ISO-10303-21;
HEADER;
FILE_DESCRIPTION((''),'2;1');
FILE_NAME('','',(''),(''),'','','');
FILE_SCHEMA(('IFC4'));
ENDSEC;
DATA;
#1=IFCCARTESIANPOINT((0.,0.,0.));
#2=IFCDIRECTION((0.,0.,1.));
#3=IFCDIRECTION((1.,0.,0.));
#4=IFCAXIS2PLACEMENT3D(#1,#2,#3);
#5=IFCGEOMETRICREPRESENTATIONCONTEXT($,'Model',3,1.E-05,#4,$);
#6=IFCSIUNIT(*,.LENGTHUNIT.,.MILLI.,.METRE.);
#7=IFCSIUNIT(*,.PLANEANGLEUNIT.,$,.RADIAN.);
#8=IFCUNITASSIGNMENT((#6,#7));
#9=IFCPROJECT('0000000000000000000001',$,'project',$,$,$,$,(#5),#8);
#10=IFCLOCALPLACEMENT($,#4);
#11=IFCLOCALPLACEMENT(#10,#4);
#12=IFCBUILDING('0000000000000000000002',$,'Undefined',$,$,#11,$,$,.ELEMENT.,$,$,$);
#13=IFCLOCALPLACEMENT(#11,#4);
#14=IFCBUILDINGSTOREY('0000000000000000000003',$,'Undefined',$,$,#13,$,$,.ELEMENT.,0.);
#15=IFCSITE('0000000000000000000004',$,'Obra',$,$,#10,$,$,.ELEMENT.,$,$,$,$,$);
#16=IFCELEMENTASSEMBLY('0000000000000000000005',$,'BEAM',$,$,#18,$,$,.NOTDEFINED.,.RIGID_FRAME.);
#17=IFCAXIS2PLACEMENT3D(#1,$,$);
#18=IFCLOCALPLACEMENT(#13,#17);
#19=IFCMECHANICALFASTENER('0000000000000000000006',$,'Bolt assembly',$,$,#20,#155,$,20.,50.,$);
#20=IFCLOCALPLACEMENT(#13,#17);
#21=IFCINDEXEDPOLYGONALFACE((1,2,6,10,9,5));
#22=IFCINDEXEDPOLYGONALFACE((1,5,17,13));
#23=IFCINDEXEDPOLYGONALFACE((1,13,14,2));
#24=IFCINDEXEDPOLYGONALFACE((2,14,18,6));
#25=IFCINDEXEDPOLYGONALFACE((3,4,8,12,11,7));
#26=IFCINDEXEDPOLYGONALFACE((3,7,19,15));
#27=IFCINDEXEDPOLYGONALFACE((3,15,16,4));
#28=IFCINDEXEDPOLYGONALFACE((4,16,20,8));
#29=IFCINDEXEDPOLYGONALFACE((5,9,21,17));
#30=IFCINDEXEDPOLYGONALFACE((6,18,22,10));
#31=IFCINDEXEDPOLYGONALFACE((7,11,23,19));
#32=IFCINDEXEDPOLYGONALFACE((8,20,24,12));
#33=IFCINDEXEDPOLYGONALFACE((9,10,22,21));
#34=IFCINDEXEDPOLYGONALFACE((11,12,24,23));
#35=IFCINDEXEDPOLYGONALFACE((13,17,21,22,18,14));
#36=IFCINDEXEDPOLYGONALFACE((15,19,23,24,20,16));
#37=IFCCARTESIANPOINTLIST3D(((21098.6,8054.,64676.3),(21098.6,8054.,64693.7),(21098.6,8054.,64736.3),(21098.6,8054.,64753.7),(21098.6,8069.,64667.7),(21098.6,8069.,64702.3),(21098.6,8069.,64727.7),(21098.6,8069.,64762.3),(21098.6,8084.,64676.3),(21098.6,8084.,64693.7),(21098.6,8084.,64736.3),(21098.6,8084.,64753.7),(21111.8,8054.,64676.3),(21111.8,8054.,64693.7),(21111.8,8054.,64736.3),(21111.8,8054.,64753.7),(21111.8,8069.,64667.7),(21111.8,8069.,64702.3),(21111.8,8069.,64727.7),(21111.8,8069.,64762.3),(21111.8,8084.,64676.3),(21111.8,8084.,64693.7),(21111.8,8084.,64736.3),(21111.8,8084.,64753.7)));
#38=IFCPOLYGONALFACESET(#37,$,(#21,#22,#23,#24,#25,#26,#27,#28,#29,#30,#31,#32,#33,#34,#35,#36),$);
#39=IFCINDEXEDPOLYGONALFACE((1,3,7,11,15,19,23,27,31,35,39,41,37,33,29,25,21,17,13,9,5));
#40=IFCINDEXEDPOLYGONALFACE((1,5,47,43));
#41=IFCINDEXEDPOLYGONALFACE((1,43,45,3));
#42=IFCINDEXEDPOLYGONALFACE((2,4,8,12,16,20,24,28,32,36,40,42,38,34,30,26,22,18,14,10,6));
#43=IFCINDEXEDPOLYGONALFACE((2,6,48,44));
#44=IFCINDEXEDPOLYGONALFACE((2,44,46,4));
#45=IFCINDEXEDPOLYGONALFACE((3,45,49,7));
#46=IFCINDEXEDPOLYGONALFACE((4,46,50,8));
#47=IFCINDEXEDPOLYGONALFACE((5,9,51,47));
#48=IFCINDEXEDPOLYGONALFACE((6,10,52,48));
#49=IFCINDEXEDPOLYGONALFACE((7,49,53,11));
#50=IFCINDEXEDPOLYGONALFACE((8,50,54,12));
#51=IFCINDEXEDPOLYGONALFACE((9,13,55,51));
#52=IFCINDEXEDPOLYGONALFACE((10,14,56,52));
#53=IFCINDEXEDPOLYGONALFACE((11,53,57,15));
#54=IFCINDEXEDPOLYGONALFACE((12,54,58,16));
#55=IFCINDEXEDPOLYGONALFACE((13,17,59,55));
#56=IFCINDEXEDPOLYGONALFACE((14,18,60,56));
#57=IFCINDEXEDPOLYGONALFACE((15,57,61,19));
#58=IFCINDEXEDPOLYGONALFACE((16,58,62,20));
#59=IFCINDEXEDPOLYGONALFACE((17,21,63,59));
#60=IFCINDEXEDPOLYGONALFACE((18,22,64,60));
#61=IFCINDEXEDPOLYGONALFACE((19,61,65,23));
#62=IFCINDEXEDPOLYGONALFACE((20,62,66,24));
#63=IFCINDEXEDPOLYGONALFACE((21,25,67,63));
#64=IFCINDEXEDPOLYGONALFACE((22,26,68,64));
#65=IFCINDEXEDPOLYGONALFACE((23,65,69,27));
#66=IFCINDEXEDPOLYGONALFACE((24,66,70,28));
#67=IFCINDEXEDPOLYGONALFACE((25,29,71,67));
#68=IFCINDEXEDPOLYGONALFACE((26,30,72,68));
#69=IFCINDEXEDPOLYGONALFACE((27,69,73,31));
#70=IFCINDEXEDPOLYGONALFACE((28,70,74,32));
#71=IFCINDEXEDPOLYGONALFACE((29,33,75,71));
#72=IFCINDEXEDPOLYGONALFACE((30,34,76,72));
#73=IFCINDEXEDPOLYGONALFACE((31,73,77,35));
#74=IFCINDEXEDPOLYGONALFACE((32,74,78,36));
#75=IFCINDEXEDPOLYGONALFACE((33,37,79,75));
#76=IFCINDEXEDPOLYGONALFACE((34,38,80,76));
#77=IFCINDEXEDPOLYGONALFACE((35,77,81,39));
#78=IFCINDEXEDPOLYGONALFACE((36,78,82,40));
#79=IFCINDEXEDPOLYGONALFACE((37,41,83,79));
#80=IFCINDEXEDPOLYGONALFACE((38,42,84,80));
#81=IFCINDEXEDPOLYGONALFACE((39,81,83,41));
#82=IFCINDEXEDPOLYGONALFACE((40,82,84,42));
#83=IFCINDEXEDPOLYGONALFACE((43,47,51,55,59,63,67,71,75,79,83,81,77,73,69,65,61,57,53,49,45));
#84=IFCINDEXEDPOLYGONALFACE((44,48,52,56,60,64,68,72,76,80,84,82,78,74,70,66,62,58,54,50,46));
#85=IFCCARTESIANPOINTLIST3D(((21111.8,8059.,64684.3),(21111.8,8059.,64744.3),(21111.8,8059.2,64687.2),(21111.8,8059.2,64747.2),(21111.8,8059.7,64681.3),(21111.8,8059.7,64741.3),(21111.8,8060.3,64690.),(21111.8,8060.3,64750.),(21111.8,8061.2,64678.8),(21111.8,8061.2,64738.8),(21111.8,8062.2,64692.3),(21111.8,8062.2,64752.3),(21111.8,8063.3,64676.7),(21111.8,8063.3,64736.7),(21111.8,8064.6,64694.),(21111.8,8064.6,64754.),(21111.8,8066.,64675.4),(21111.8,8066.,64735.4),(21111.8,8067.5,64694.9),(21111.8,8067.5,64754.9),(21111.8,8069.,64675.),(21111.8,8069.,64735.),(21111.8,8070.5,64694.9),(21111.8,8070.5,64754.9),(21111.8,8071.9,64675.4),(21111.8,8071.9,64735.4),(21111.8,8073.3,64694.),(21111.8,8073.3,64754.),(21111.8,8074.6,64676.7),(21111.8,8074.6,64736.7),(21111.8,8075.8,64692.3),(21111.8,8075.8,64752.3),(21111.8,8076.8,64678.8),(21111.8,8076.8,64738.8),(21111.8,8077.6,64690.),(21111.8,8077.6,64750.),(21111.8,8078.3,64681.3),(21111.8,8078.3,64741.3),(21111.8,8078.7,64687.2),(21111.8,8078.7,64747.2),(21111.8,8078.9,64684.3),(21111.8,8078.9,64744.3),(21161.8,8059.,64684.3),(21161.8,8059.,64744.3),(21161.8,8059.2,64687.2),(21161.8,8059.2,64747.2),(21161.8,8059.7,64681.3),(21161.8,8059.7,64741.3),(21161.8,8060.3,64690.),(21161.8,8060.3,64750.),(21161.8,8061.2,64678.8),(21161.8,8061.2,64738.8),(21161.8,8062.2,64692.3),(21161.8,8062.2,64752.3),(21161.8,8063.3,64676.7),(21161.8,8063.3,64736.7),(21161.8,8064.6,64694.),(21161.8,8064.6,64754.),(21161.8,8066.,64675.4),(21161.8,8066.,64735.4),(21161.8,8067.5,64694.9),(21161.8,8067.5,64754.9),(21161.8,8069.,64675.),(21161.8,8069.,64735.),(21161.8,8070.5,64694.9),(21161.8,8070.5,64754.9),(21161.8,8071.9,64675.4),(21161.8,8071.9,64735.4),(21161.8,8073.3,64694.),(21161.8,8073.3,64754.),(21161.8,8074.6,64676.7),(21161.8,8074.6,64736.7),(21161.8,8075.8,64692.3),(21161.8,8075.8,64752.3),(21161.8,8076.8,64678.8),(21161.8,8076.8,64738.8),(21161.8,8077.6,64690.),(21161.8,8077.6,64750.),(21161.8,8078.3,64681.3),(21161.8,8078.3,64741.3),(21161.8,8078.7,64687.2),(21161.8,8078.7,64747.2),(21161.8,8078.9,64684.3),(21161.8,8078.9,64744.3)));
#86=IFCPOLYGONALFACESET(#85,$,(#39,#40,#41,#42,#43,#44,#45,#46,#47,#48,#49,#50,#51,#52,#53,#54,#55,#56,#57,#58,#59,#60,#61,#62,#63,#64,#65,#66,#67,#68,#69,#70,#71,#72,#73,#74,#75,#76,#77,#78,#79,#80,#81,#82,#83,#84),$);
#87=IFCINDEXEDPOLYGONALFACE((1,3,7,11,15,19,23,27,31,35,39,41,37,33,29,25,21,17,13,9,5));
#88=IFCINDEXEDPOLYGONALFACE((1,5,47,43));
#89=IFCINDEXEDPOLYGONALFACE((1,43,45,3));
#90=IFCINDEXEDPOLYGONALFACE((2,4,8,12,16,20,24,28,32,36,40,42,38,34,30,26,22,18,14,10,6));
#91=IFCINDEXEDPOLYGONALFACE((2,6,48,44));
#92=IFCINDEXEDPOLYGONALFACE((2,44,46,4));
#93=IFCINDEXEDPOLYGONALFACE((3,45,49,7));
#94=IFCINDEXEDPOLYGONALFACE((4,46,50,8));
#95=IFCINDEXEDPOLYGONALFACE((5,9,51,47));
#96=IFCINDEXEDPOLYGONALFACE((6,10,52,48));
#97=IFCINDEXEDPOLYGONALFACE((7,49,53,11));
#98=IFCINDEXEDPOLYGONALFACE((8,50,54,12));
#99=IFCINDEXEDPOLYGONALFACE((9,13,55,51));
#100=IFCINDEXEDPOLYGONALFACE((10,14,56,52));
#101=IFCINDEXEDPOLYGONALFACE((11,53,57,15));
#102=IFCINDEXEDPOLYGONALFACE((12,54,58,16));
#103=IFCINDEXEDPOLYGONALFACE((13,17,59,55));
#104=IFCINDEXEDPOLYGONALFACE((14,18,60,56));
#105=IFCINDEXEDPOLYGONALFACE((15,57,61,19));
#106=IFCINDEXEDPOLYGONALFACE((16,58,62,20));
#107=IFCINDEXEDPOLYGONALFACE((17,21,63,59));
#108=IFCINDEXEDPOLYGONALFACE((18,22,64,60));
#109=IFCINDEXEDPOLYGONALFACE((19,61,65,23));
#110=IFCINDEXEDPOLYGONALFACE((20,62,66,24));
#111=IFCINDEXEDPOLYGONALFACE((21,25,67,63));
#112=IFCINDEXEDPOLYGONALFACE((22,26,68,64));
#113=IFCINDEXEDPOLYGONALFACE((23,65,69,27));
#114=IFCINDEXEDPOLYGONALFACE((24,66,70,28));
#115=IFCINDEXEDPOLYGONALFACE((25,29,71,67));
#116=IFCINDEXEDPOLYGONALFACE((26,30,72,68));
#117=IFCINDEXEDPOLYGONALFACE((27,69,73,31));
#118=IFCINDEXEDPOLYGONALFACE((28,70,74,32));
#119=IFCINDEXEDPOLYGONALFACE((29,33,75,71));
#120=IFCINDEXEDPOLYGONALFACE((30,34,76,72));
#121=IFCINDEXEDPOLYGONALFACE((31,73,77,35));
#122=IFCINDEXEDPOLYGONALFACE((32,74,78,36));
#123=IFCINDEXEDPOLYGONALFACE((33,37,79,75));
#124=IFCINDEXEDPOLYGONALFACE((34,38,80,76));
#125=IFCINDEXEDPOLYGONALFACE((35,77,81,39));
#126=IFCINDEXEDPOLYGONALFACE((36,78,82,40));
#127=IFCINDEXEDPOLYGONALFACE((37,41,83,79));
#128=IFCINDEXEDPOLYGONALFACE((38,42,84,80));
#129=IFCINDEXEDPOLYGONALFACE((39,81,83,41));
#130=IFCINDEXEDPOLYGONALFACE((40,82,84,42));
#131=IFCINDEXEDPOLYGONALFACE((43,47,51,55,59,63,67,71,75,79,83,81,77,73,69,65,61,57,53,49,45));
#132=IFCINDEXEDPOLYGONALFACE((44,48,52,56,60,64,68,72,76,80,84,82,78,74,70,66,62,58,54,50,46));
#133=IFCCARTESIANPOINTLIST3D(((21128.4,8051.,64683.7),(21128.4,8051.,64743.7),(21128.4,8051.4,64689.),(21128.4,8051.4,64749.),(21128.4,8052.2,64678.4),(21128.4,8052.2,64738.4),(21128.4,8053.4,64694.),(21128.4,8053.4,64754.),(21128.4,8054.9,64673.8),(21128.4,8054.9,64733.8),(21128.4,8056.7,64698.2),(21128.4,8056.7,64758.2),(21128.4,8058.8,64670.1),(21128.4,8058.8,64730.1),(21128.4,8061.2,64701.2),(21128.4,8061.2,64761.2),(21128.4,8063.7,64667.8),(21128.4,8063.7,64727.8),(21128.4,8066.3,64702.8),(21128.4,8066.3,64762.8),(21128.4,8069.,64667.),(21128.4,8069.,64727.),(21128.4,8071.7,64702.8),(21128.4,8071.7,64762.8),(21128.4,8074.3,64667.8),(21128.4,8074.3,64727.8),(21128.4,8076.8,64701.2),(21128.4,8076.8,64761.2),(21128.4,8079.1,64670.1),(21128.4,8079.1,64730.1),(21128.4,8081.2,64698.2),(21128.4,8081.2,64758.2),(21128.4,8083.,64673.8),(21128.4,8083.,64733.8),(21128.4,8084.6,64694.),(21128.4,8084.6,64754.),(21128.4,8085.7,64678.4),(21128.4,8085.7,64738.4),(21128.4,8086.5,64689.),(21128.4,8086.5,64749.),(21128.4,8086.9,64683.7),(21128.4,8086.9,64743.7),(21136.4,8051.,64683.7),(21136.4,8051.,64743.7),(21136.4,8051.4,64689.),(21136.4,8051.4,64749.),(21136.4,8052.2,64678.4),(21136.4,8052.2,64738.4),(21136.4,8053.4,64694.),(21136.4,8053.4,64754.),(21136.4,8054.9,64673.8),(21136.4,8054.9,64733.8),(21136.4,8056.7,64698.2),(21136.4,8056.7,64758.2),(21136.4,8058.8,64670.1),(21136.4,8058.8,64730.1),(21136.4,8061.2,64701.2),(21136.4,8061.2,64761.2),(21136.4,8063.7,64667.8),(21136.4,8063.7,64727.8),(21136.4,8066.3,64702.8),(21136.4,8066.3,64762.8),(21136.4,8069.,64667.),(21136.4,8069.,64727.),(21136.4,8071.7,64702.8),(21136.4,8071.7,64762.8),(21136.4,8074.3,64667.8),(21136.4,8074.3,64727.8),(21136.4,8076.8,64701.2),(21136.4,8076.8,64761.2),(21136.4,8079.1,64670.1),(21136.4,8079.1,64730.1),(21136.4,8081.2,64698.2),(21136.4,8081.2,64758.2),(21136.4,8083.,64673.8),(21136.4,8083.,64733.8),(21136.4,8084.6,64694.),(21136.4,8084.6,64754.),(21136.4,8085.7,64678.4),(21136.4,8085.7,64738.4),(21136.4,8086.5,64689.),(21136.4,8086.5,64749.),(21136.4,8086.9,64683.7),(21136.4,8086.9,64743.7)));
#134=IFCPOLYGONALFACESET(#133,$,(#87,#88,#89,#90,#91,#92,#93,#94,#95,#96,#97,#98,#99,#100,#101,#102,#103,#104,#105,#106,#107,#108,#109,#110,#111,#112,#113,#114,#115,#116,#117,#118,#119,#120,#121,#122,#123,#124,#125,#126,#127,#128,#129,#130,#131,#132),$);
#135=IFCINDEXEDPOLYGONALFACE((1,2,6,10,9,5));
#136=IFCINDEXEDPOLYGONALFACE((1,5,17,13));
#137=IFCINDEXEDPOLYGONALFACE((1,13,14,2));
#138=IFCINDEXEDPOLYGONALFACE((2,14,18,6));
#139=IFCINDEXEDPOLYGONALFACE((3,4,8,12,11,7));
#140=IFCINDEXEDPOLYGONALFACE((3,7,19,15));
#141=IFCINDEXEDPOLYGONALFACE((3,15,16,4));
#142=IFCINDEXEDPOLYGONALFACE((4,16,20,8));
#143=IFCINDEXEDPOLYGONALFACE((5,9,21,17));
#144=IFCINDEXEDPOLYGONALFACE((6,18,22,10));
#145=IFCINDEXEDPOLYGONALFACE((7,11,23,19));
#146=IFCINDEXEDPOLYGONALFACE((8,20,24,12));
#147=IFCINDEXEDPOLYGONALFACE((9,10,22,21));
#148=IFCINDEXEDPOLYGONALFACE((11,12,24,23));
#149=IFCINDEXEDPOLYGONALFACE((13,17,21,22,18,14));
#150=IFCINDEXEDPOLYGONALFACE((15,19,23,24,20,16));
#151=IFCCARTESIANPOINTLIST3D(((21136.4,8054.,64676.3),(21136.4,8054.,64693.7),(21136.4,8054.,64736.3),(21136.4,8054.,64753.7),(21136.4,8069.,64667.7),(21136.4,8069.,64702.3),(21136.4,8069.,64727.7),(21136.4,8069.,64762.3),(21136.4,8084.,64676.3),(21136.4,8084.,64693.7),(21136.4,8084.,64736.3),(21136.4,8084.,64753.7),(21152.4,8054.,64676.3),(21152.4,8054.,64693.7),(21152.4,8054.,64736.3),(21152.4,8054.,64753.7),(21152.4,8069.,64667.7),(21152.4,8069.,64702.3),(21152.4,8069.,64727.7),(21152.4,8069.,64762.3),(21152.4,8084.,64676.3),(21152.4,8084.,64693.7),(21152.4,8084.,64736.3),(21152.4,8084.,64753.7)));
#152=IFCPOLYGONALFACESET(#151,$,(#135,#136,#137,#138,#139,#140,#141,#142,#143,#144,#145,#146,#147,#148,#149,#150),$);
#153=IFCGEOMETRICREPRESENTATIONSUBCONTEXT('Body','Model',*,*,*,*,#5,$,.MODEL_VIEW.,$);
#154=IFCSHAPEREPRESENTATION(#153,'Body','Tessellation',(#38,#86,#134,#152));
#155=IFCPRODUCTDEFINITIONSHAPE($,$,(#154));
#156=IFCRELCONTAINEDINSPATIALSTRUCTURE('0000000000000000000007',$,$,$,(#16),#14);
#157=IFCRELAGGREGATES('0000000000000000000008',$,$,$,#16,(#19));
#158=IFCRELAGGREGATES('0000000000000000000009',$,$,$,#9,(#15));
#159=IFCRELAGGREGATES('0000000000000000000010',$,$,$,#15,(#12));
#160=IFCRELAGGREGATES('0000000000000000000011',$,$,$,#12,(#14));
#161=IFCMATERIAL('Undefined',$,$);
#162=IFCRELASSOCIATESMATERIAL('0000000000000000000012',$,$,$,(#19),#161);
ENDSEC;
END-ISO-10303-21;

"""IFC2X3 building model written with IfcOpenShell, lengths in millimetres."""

from ifc_helpers import new_model, si_unit, frame, origin_with_axes, origin_2d_with_axis, place, context, subcontext, project, spatial, polyline, circle, outline, extrude, source, transform, mapped, material, element, aggregate, save


model = new_model("IFC2X3")

# Units and contexts
model_context = context("Model", 3, precision=1e-05, world=origin_with_axes())
body_context = subcontext(model_context, "Body", "Model", "MODEL_VIEW")
ifc_project = project(units=[si_unit("LENGTHUNIT", "METRE", prefix="MILLI"), si_unit("PLANEANGLEUNIT", "RADIAN")], contexts=[model_context])

# Site, building, storey
site_placement = place(None, origin_with_axes())
site = spatial("IfcSite", under=ifc_project, at=site_placement, Name="Obra", CompositionType="ELEMENT")
building_placement = place(site_placement, origin_with_axes())
building = spatial("IfcBuilding", under=site, at=building_placement, Name="Undefined", CompositionType="ELEMENT")
storey_placement = place(building_placement, origin_with_axes())
storey = spatial("IfcBuildingStorey", under=building, at=storey_placement, Name="Undefined", CompositionType="ELEMENT", Elevation=0.0)

# Shared definitions
ifc_material = material(Name="Undefined")
shared_shape_1 = source(origin_with_axes(), body_context, "Body", "SweptSolid", [
    extrude(outline(polyline([(17.3, 0.0), (8.7, 15.0), (-8.7, 15.0), (-17.3, 0.0), (-8.7, -15.0), (8.7, -15.0), (17.3, 0.0)])), frame((0.0, -26.5, 0.0), z_axis=(0.0, 1.0, 0.0), x_axis=(1.0, 0.0, 0.0)), (0.0, 0.0, 1.0), 13.2),
    extrude(circle(Radius=10.0, at=origin_2d_with_axis()), frame((0.0, -13.3, 0.0), z_axis=(0.0, 1.0, 0.0), x_axis=(1.0, 0.0, 0.0)), (0.0, 0.0, 1.0), 50.0),
    extrude(circle(Radius=18.0, at=origin_2d_with_axis()), frame((0.0, 3.3, 0.0), z_axis=(0.0, 1.0, 0.0), x_axis=(1.0, 0.0, 0.0)), (0.0, 0.0, 1.0), 8.0),
    extrude(outline(polyline([(17.3, 0.0), (8.7, 15.0), (-8.7, 15.0), (-17.3, 0.0), (-8.7, -15.0), (8.7, -15.0), (17.3, 0.0)])), frame((0.0, 11.3, 0.0), z_axis=(0.0, 1.0, 0.0), x_axis=(1.0, 0.0, 0.0)), (0.0, 0.0, 1.0), 16.0),
])

# Element assembly, mechanical fastener
assembly_1_placement = place(storey_placement, origin_with_axes())
assembly_1 = element("IfcElementAssembly", 1, at=assembly_1_placement, inside=storey, Name="BEAM", AssemblyPlace="NOTDEFINED", PredefinedType="RIGID_FRAME")
mechanical_fastener_1_placement = place(assembly_1_placement, frame((21125.1, 8109.0, 64850.0), z_axis=(0.0, -1.0, 0.0), x_axis=(0.0, 0.0, -1.0)))
mechanical_fastener_1 = element("IfcMechanicalFastener", 2, at=mechanical_fastener_1_placement, material=ifc_material, Name="Bolt assembly", NominalDiameter=20.0, NominalLength=50.0, context=body_context, shape_type="MappedRepresentation", body=[
    mapped(shared_shape_1, transform((105.0, 0.0, 40.0))),
    mapped(shared_shape_1, transform((165.0, 0.0, 40.0))),
])
aggregate(assembly_1, [mechanical_fastener_1])

save(model, "model.ifc")
